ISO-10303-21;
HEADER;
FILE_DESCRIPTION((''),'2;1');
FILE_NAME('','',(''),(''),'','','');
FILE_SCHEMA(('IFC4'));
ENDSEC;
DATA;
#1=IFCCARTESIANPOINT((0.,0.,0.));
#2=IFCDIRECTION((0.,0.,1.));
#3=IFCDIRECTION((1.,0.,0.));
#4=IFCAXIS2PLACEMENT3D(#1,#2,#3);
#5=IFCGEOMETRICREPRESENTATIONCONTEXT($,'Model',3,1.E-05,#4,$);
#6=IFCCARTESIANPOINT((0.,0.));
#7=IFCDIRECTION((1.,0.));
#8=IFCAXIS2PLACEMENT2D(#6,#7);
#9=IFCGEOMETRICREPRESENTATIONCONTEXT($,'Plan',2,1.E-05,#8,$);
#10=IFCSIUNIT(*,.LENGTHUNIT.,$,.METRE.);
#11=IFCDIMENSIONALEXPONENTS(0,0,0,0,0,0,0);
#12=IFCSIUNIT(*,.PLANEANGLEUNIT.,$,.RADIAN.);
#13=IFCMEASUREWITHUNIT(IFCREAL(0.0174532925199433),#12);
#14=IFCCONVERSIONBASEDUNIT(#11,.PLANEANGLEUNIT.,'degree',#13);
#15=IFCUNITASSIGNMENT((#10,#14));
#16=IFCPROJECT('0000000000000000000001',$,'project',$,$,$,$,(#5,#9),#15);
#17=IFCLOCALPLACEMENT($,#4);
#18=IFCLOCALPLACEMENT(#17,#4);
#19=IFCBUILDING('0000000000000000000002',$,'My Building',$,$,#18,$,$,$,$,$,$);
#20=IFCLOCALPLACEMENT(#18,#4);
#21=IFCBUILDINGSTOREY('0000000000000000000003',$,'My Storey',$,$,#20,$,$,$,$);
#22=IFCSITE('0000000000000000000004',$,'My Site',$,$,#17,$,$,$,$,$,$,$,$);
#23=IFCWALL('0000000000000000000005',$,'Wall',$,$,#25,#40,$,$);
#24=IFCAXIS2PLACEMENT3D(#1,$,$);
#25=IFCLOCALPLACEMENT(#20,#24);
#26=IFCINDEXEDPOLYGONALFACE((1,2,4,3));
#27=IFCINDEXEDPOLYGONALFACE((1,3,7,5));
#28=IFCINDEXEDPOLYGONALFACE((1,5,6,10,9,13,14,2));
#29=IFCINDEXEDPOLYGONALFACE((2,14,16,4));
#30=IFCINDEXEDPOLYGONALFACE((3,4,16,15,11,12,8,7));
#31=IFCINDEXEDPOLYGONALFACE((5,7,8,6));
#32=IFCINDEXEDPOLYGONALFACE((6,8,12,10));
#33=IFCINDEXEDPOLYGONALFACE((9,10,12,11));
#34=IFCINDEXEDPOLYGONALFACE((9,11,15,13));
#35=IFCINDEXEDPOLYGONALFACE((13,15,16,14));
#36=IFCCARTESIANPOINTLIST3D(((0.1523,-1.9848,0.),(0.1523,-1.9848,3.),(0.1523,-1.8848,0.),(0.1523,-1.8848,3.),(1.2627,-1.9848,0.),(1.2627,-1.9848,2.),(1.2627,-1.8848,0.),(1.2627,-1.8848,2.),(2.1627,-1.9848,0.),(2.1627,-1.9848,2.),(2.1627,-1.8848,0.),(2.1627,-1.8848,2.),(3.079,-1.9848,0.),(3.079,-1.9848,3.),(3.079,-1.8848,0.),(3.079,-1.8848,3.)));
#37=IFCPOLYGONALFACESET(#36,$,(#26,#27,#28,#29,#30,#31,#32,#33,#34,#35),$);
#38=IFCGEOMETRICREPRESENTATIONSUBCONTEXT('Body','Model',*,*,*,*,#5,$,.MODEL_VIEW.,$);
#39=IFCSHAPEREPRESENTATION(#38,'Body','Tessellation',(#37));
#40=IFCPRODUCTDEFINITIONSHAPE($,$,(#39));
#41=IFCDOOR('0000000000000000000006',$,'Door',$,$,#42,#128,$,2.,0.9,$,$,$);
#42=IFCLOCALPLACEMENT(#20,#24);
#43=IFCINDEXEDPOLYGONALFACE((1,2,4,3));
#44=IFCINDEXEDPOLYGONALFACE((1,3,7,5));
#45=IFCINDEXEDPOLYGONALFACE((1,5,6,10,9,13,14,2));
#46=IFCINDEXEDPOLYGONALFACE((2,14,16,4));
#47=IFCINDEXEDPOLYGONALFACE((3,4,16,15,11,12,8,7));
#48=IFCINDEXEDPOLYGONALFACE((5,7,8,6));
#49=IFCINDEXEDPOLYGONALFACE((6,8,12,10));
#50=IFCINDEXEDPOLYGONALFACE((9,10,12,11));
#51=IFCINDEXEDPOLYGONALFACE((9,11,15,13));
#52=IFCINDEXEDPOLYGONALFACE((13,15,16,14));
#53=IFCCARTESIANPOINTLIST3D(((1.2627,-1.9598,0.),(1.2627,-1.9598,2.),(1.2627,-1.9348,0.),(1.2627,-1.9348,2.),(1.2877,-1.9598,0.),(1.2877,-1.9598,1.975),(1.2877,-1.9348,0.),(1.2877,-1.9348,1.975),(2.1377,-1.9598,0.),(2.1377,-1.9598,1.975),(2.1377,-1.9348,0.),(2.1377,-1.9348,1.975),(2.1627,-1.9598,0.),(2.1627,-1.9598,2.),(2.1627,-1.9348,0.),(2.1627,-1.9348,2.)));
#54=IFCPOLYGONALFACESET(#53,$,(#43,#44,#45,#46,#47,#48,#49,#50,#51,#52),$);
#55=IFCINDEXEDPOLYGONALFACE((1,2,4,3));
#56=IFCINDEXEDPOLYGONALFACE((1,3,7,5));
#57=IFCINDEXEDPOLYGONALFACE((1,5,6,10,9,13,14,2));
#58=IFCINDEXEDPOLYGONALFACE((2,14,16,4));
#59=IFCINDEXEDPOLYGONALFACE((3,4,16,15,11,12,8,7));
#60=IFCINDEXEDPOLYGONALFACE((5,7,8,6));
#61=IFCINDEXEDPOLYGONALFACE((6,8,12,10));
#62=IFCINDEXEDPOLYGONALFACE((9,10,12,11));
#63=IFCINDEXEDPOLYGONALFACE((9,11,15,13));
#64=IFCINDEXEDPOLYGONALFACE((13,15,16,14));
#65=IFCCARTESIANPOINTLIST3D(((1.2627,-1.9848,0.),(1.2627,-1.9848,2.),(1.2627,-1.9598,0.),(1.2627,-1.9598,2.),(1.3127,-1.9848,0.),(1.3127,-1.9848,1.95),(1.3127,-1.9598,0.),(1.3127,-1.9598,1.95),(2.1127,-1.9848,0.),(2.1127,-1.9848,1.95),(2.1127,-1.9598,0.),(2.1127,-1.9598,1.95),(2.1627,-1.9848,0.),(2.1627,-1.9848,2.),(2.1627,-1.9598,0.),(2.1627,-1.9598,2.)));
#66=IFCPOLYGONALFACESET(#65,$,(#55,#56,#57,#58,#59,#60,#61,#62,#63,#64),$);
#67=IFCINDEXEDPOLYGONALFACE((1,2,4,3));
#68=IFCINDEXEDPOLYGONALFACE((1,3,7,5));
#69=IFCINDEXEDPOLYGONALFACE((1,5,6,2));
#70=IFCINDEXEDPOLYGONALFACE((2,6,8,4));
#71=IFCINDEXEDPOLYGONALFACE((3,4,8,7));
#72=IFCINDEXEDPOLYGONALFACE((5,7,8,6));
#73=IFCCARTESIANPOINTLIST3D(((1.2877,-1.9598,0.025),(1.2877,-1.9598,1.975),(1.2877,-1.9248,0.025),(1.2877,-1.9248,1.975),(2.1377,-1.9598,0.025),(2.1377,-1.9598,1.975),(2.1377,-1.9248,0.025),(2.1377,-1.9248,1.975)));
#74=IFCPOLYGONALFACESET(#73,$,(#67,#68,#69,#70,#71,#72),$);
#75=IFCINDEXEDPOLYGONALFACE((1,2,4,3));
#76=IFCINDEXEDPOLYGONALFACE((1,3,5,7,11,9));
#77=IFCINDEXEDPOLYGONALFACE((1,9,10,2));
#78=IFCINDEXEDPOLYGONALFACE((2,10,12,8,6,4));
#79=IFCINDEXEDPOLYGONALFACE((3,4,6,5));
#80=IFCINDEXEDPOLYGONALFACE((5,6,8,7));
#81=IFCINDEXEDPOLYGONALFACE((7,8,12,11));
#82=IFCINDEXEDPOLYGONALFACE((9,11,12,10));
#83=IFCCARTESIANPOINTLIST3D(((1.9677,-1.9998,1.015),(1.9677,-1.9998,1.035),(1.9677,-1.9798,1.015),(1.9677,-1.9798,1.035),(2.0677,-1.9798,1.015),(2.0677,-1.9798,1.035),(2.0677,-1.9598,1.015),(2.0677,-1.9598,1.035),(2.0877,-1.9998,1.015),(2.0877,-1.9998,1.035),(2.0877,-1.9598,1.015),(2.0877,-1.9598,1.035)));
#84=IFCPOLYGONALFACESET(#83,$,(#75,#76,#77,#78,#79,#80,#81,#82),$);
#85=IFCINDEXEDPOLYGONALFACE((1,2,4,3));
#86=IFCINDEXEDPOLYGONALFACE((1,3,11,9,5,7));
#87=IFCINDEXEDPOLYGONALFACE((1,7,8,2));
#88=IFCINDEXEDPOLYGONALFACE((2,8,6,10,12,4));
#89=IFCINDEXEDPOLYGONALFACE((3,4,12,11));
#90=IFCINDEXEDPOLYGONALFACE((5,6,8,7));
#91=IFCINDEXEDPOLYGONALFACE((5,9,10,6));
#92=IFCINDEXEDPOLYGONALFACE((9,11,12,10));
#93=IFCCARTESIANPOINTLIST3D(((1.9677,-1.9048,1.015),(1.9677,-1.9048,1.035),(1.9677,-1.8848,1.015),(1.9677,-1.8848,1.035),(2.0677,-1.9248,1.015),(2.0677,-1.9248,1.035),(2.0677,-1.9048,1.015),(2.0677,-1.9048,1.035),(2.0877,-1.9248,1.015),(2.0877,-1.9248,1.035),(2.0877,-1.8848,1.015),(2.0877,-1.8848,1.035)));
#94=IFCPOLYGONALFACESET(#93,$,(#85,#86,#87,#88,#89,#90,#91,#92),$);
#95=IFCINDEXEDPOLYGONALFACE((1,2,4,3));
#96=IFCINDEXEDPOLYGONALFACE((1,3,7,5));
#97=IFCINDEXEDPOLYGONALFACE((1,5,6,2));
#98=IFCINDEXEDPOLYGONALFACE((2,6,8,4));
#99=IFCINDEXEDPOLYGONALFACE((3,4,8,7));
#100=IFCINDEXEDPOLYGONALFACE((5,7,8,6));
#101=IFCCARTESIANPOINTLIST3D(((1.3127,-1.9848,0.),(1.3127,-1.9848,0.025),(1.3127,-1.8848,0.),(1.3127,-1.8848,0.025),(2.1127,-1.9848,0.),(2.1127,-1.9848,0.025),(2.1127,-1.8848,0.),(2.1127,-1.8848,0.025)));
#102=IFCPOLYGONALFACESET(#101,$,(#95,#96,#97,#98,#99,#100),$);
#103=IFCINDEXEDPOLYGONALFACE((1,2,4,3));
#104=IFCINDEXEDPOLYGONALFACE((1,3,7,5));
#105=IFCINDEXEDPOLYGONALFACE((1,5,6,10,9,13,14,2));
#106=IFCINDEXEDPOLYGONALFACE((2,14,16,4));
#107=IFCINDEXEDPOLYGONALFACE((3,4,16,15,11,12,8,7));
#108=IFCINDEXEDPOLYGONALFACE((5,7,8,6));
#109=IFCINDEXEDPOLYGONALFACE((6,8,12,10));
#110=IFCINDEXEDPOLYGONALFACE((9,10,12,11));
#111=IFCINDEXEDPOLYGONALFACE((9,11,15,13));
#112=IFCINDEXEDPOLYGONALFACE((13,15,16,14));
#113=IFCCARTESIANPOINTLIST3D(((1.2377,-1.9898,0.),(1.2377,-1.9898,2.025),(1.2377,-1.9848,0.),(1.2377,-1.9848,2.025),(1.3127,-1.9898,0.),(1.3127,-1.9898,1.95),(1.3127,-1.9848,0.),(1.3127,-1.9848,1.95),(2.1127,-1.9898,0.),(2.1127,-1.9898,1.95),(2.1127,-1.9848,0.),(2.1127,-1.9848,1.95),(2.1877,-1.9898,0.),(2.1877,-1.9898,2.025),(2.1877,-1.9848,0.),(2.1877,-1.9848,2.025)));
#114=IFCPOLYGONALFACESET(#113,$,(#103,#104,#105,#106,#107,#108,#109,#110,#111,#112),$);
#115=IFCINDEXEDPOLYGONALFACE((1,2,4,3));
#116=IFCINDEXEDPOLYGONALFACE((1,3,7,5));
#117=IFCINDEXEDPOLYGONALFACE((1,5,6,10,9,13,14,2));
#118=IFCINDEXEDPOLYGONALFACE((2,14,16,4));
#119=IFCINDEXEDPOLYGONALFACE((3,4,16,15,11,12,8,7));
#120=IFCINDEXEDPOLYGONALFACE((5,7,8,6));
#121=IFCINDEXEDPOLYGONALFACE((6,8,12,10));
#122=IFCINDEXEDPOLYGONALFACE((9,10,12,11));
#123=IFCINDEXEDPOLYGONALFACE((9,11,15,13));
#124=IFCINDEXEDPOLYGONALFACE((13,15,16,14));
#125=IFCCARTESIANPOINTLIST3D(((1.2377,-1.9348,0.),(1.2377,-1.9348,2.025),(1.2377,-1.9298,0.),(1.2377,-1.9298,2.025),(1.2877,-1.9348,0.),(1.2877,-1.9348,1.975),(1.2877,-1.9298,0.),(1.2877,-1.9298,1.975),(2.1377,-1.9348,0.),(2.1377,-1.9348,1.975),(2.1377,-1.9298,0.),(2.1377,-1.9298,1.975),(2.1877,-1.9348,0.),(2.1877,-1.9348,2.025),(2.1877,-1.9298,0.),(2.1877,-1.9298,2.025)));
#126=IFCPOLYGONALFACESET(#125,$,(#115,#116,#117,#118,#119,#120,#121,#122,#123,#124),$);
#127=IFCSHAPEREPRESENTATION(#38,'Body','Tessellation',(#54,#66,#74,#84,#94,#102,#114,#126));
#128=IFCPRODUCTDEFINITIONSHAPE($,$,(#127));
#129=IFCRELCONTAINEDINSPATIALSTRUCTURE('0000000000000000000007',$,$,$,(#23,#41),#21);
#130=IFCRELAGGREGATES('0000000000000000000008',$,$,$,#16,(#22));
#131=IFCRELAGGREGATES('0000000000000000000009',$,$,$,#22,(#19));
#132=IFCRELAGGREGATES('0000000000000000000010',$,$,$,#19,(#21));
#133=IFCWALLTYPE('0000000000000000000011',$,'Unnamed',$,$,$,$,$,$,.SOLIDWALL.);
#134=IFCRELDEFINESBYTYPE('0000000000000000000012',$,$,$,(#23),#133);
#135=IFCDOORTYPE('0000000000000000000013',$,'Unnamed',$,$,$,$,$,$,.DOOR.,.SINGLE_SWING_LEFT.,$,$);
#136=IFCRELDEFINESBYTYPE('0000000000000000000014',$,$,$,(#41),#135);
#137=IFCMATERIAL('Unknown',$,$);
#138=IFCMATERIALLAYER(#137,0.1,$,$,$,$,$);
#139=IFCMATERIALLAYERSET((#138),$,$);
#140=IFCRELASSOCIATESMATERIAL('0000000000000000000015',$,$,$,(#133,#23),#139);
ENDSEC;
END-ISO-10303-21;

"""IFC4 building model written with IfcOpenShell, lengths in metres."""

from ifc_helpers import new_model, entity, si_unit, converted_unit, frame, origin_with_axes, origin_2d_with_axis, place, context, subcontext, project, spatial, line, indexed_curve, outline, extrude, shape, source, transform, mapped, material, layer, layer_set, layer_usage, type_object, type_shapes, element, fill, save


model = new_model("IFC4")

# Units and contexts
model_context = context("Model", 3, precision=1e-05, world=origin_with_axes())
plan_context = context("Plan", 2, precision=1e-05, world=origin_2d_with_axis())
body_context_1 = subcontext(model_context, "Body", "Model", "MODEL_VIEW")
body_context_2 = subcontext(plan_context, "Body", "Plan", "PLAN_VIEW")
ifc_project = project(units=[si_unit("LENGTHUNIT", "METRE"), converted_unit("PLANEANGLEUNIT", "degree", entity("IfcReal", 0.0174532925199433), si_unit("PLANEANGLEUNIT", "RADIAN"), dimensions=[0, 0, 0, 0, 0, 0, 0])], contexts=[model_context, plan_context])

# Site, building, storey
site_placement = place(None, origin_with_axes())
site = spatial("IfcSite", under=ifc_project, at=site_placement, Name="My Site")
building_placement = place(site_placement, origin_with_axes())
building = spatial("IfcBuilding", under=site, at=building_placement, Name="My Building")
storey_placement = place(building_placement, origin_with_axes())
storey = spatial("IfcBuildingStorey", under=building, at=storey_placement, Name="My Storey")

# Shared definitions
ifc_material = material(Name="Unknown")

# Shared definitions
ifc_layer_1 = layer(ifc_material, 0.1)
ifc_layer_set_1 = layer_set([ifc_layer_1])
wall_type = type_object("IfcWallType", Name="Unnamed", PredefinedType="SOLIDWALL", material=ifc_layer_set_1)

# Shared definitions
shared_shape_1 = source(origin_with_axes(), body_context_1, "Body", "SweptSolid", [
    extrude(outline(indexed_curve([(0.0, 0.0), (0.9, 0.0), (0.9, 2.0), (0.0, 2.0)], segments=[line(1, 2, 3, 4, 1)])), frame((0.0, -0.6, 0.0), z_axis=(0.0, -1.0, 0.0), x_axis=(1.0, 0.0, 0.0)), (0.0, 0.0, -1.0), 1.2),
])
door_type = type_object("IfcDoorType", Name="Unnamed", OperationType="SINGLE_SWING_LEFT", PredefinedType="DOOR")
shared_shape_2 = source(origin_with_axes(), body_context_1, "Body", "SweptSolid", [
    extrude(outline(indexed_curve([(0.0, 0.0), (0.0, 2.0), (0.9, 2.0), (0.9, 0.0), (0.875, 0.0), (0.875, 1.975), (0.025, 1.975), (0.025, 0.0)], segments=[line(1, 2, 3, 4, 5, 6, 7, 8, 1)])), frame((0.0, 0.025, 0.0), z_axis=(0.0, -1.0, 0.0), x_axis=(1.0, 0.0, 0.0)), (0.0, 0.0, -1.0), 0.025),
    extrude(outline(indexed_curve([(0.0, 0.0), (0.0, 2.0), (0.9, 2.0), (0.9, 0.0), (0.85, 0.0), (0.85, 1.95), (0.05, 1.95), (0.05, 0.0)], segments=[line(1, 2, 3, 4, 5, 6, 7, 8, 1)])), frame((0.0, 0.0, 0.0), z_axis=(0.0, -1.0, 0.0), x_axis=(1.0, 0.0, 0.0)), (0.0, 0.0, -1.0), 0.025),
    extrude(outline(indexed_curve([(0.0, 0.0), (0.85, 0.0), (0.85, 0.035), (0.0, 0.035)], segments=[line(1, 2, 3, 4, 1)])), frame((0.025, 0.025, 0.025), z_axis=(0.0, 0.0, 1.0), x_axis=(1.0, 0.0, 0.0)), (0.0, 0.0, 1.0), 1.95),
    extrude(outline(indexed_curve([(0.0, 0.0), (0.0, -0.04), (-0.12, -0.04), (-0.12, -0.02), (-0.02, -0.02), (-0.02, 0.0)], segments=[line(1, 2, 3, 4, 5, 6, 1)])), frame((0.825, 0.025, 1.015), z_axis=(0.0, 0.0, 1.0), x_axis=(1.0, 0.0, 0.0)), (0.0, 0.0, 1.0), 0.02),
    extrude(outline(indexed_curve([(0.0, 0.0), (0.0, 0.04), (-0.12, 0.04), (-0.12, 0.02), (-0.02, 0.02), (-0.02, 0.0)], segments=[line(1, 2, 3, 4, 5, 6, 1)])), frame((0.825, 0.06, 1.015), z_axis=(0.0, 0.0, 1.0), x_axis=(1.0, 0.0, 0.0)), (0.0, 0.0, 1.0), 0.02),
    extrude(outline(indexed_curve([(0.0, 0.0), (0.8, 0.0), (0.8, 0.1), (0.0, 0.1)], segments=[line(1, 2, 3, 4, 1)])), frame((0.05, 0.0, 0.0), z_axis=(0.0, 0.0, 1.0), x_axis=(1.0, 0.0, 0.0)), (0.0, 0.0, 1.0), 0.025),
    extrude(outline(indexed_curve([(0.0, 0.0), (0.0, 2.025), (0.95, 2.025), (0.95, 0.0), (0.875, 0.0), (0.875, 1.95), (0.075, 1.95), (0.075, 0.0)], segments=[line(1, 2, 3, 4, 5, 6, 7, 8, 1)])), frame((-0.025, -0.005, 0.0), z_axis=(0.0, -1.0, 0.0), x_axis=(1.0, 0.0, 0.0)), (0.0, 0.0, -1.0), 0.005),
    extrude(outline(indexed_curve([(0.0, 0.0), (0.0, 2.025), (0.95, 2.025), (0.95, 0.0), (0.9, 0.0), (0.9, 1.975), (0.05, 1.975), (0.05, 0.0)], segments=[line(1, 2, 3, 4, 5, 6, 7, 8, 1)])), frame((-0.025, 0.05, 0.0), z_axis=(0.0, -1.0, 0.0), x_axis=(1.0, 0.0, 0.0)), (0.0, 0.0, -1.0), 0.005),
])
shared_shape_3 = source(origin_with_axes(), body_context_2, "Body", "Curve2D", [
    entity("IfcIndexedPolyCurve", entity("IfcCartesianPointList2D", [[0.0, 0.0], [0.0, 0.05], [0.025, 0.05], [0.025, 0.025], [0.05, 0.025], [0.05, 0.0]]), [entity("IfcLineIndex", [1, 2, 3, 4, 5, 6, 1])]),
    entity("IfcIndexedPolyCurve", entity("IfcCartesianPointList2D", [[0.9, 0.0], [0.9, 0.05], [0.875, 0.05], [0.875, 0.025], [0.85, 0.025], [0.85, 0.0]]), [entity("IfcLineIndex", [1, 2, 3, 4, 5, 6, 1])]),
    entity("IfcTrimmedCurve", entity("IfcEllipse", entity("IfcAxis2Placement2D", entity("IfcCartesianPoint", [0.06, 0.05]), entity("IfcDirection", [1.0, 0.0])), 0.815, 0.85), [entity("IfcCartesianPoint", [0.875, 0.05])], [entity("IfcCartesianPoint", [0.06, 0.9])], True, "CARTESIAN"),
    entity("IfcIndexedPolyCurve", entity("IfcCartesianPointList2D", [[0.025, 0.05], [0.06, 0.05], [0.06, 0.9], [0.025, 0.9]]), [entity("IfcLineIndex", [1, 2, 3, 4, 1])]),
])
type_shapes(door_type, [shared_shape_2, shared_shape_3])

# Wall, opening, door
ifc_layer_usage_1 = layer_usage(ifc_layer_set_1, "AXIS2", "POSITIVE", 0.0)
wall_1_placement = place(storey_placement, frame((0.1523, -1.9848, 0.0), z_axis=(0.0, 0.0, 1.0), x_axis=(1.0, 0.0, 0.0)))
wall_1 = element("IfcWall", 1, at=wall_1_placement, inside=storey, type_object=wall_type, material=ifc_layer_usage_1, Name="Wall", context=body_context_1, shape_type="SweptSolid", body=[
    extrude(outline(indexed_curve([(0.0, 0.0), (0.0, 0.1), (2.9267, 0.1), (2.9267, 0.0)], segments=[line(1, 2, 3, 4, 1)])), origin_with_axes(), (0.0, 0.0, 1.0), 3.0),
])
opening_1_placement = place(wall_1_placement, frame((1.1104, 0.0, 0.0), z_axis=(0.0, 0.0, 1.0), x_axis=(1.0, 0.0, 0.0)))
opening_1 = element("IfcOpeningElement", 2, at=opening_1_placement, cuts=wall_1, PredefinedType="OPENING", context=body_context_1, shape_type="MappedRepresentation", body=[
    mapped(shared_shape_1, transform((0.0, 0.0, 0.0), x_axis=(1.0, 0.0, 0.0), y_axis=(0.0, 1.0, 0.0), z_axis=(0.0, 0.0, 1.0), scale=1.0)),
])
door_1_placement = place(opening_1_placement, origin_with_axes())
door_1 = element("IfcDoor", 3, at=door_1_placement, inside=storey, type_object=door_type, Name="Door", OverallHeight=2.0, OverallWidth=0.9, shapes=[
    shape(body_context_1, "Body", "MappedRepresentation", [mapped(shared_shape_2, transform((0.0, 0.0, 0.0), x_axis=(1.0, 0.0, 0.0), y_axis=(0.0, 1.0, 0.0), z_axis=(0.0, 0.0, 1.0), scale=1.0))]),
    shape(body_context_2, "Body", "MappedRepresentation", [mapped(shared_shape_3, transform((0.0, 0.0, 0.0), x_axis=(1.0, 0.0, 0.0), y_axis=(0.0, 1.0, 0.0), z_axis=(0.0, 0.0, 1.0), scale=1.0))]),
])
fill(opening_1, door_1)

save(model, "model.ifc")
